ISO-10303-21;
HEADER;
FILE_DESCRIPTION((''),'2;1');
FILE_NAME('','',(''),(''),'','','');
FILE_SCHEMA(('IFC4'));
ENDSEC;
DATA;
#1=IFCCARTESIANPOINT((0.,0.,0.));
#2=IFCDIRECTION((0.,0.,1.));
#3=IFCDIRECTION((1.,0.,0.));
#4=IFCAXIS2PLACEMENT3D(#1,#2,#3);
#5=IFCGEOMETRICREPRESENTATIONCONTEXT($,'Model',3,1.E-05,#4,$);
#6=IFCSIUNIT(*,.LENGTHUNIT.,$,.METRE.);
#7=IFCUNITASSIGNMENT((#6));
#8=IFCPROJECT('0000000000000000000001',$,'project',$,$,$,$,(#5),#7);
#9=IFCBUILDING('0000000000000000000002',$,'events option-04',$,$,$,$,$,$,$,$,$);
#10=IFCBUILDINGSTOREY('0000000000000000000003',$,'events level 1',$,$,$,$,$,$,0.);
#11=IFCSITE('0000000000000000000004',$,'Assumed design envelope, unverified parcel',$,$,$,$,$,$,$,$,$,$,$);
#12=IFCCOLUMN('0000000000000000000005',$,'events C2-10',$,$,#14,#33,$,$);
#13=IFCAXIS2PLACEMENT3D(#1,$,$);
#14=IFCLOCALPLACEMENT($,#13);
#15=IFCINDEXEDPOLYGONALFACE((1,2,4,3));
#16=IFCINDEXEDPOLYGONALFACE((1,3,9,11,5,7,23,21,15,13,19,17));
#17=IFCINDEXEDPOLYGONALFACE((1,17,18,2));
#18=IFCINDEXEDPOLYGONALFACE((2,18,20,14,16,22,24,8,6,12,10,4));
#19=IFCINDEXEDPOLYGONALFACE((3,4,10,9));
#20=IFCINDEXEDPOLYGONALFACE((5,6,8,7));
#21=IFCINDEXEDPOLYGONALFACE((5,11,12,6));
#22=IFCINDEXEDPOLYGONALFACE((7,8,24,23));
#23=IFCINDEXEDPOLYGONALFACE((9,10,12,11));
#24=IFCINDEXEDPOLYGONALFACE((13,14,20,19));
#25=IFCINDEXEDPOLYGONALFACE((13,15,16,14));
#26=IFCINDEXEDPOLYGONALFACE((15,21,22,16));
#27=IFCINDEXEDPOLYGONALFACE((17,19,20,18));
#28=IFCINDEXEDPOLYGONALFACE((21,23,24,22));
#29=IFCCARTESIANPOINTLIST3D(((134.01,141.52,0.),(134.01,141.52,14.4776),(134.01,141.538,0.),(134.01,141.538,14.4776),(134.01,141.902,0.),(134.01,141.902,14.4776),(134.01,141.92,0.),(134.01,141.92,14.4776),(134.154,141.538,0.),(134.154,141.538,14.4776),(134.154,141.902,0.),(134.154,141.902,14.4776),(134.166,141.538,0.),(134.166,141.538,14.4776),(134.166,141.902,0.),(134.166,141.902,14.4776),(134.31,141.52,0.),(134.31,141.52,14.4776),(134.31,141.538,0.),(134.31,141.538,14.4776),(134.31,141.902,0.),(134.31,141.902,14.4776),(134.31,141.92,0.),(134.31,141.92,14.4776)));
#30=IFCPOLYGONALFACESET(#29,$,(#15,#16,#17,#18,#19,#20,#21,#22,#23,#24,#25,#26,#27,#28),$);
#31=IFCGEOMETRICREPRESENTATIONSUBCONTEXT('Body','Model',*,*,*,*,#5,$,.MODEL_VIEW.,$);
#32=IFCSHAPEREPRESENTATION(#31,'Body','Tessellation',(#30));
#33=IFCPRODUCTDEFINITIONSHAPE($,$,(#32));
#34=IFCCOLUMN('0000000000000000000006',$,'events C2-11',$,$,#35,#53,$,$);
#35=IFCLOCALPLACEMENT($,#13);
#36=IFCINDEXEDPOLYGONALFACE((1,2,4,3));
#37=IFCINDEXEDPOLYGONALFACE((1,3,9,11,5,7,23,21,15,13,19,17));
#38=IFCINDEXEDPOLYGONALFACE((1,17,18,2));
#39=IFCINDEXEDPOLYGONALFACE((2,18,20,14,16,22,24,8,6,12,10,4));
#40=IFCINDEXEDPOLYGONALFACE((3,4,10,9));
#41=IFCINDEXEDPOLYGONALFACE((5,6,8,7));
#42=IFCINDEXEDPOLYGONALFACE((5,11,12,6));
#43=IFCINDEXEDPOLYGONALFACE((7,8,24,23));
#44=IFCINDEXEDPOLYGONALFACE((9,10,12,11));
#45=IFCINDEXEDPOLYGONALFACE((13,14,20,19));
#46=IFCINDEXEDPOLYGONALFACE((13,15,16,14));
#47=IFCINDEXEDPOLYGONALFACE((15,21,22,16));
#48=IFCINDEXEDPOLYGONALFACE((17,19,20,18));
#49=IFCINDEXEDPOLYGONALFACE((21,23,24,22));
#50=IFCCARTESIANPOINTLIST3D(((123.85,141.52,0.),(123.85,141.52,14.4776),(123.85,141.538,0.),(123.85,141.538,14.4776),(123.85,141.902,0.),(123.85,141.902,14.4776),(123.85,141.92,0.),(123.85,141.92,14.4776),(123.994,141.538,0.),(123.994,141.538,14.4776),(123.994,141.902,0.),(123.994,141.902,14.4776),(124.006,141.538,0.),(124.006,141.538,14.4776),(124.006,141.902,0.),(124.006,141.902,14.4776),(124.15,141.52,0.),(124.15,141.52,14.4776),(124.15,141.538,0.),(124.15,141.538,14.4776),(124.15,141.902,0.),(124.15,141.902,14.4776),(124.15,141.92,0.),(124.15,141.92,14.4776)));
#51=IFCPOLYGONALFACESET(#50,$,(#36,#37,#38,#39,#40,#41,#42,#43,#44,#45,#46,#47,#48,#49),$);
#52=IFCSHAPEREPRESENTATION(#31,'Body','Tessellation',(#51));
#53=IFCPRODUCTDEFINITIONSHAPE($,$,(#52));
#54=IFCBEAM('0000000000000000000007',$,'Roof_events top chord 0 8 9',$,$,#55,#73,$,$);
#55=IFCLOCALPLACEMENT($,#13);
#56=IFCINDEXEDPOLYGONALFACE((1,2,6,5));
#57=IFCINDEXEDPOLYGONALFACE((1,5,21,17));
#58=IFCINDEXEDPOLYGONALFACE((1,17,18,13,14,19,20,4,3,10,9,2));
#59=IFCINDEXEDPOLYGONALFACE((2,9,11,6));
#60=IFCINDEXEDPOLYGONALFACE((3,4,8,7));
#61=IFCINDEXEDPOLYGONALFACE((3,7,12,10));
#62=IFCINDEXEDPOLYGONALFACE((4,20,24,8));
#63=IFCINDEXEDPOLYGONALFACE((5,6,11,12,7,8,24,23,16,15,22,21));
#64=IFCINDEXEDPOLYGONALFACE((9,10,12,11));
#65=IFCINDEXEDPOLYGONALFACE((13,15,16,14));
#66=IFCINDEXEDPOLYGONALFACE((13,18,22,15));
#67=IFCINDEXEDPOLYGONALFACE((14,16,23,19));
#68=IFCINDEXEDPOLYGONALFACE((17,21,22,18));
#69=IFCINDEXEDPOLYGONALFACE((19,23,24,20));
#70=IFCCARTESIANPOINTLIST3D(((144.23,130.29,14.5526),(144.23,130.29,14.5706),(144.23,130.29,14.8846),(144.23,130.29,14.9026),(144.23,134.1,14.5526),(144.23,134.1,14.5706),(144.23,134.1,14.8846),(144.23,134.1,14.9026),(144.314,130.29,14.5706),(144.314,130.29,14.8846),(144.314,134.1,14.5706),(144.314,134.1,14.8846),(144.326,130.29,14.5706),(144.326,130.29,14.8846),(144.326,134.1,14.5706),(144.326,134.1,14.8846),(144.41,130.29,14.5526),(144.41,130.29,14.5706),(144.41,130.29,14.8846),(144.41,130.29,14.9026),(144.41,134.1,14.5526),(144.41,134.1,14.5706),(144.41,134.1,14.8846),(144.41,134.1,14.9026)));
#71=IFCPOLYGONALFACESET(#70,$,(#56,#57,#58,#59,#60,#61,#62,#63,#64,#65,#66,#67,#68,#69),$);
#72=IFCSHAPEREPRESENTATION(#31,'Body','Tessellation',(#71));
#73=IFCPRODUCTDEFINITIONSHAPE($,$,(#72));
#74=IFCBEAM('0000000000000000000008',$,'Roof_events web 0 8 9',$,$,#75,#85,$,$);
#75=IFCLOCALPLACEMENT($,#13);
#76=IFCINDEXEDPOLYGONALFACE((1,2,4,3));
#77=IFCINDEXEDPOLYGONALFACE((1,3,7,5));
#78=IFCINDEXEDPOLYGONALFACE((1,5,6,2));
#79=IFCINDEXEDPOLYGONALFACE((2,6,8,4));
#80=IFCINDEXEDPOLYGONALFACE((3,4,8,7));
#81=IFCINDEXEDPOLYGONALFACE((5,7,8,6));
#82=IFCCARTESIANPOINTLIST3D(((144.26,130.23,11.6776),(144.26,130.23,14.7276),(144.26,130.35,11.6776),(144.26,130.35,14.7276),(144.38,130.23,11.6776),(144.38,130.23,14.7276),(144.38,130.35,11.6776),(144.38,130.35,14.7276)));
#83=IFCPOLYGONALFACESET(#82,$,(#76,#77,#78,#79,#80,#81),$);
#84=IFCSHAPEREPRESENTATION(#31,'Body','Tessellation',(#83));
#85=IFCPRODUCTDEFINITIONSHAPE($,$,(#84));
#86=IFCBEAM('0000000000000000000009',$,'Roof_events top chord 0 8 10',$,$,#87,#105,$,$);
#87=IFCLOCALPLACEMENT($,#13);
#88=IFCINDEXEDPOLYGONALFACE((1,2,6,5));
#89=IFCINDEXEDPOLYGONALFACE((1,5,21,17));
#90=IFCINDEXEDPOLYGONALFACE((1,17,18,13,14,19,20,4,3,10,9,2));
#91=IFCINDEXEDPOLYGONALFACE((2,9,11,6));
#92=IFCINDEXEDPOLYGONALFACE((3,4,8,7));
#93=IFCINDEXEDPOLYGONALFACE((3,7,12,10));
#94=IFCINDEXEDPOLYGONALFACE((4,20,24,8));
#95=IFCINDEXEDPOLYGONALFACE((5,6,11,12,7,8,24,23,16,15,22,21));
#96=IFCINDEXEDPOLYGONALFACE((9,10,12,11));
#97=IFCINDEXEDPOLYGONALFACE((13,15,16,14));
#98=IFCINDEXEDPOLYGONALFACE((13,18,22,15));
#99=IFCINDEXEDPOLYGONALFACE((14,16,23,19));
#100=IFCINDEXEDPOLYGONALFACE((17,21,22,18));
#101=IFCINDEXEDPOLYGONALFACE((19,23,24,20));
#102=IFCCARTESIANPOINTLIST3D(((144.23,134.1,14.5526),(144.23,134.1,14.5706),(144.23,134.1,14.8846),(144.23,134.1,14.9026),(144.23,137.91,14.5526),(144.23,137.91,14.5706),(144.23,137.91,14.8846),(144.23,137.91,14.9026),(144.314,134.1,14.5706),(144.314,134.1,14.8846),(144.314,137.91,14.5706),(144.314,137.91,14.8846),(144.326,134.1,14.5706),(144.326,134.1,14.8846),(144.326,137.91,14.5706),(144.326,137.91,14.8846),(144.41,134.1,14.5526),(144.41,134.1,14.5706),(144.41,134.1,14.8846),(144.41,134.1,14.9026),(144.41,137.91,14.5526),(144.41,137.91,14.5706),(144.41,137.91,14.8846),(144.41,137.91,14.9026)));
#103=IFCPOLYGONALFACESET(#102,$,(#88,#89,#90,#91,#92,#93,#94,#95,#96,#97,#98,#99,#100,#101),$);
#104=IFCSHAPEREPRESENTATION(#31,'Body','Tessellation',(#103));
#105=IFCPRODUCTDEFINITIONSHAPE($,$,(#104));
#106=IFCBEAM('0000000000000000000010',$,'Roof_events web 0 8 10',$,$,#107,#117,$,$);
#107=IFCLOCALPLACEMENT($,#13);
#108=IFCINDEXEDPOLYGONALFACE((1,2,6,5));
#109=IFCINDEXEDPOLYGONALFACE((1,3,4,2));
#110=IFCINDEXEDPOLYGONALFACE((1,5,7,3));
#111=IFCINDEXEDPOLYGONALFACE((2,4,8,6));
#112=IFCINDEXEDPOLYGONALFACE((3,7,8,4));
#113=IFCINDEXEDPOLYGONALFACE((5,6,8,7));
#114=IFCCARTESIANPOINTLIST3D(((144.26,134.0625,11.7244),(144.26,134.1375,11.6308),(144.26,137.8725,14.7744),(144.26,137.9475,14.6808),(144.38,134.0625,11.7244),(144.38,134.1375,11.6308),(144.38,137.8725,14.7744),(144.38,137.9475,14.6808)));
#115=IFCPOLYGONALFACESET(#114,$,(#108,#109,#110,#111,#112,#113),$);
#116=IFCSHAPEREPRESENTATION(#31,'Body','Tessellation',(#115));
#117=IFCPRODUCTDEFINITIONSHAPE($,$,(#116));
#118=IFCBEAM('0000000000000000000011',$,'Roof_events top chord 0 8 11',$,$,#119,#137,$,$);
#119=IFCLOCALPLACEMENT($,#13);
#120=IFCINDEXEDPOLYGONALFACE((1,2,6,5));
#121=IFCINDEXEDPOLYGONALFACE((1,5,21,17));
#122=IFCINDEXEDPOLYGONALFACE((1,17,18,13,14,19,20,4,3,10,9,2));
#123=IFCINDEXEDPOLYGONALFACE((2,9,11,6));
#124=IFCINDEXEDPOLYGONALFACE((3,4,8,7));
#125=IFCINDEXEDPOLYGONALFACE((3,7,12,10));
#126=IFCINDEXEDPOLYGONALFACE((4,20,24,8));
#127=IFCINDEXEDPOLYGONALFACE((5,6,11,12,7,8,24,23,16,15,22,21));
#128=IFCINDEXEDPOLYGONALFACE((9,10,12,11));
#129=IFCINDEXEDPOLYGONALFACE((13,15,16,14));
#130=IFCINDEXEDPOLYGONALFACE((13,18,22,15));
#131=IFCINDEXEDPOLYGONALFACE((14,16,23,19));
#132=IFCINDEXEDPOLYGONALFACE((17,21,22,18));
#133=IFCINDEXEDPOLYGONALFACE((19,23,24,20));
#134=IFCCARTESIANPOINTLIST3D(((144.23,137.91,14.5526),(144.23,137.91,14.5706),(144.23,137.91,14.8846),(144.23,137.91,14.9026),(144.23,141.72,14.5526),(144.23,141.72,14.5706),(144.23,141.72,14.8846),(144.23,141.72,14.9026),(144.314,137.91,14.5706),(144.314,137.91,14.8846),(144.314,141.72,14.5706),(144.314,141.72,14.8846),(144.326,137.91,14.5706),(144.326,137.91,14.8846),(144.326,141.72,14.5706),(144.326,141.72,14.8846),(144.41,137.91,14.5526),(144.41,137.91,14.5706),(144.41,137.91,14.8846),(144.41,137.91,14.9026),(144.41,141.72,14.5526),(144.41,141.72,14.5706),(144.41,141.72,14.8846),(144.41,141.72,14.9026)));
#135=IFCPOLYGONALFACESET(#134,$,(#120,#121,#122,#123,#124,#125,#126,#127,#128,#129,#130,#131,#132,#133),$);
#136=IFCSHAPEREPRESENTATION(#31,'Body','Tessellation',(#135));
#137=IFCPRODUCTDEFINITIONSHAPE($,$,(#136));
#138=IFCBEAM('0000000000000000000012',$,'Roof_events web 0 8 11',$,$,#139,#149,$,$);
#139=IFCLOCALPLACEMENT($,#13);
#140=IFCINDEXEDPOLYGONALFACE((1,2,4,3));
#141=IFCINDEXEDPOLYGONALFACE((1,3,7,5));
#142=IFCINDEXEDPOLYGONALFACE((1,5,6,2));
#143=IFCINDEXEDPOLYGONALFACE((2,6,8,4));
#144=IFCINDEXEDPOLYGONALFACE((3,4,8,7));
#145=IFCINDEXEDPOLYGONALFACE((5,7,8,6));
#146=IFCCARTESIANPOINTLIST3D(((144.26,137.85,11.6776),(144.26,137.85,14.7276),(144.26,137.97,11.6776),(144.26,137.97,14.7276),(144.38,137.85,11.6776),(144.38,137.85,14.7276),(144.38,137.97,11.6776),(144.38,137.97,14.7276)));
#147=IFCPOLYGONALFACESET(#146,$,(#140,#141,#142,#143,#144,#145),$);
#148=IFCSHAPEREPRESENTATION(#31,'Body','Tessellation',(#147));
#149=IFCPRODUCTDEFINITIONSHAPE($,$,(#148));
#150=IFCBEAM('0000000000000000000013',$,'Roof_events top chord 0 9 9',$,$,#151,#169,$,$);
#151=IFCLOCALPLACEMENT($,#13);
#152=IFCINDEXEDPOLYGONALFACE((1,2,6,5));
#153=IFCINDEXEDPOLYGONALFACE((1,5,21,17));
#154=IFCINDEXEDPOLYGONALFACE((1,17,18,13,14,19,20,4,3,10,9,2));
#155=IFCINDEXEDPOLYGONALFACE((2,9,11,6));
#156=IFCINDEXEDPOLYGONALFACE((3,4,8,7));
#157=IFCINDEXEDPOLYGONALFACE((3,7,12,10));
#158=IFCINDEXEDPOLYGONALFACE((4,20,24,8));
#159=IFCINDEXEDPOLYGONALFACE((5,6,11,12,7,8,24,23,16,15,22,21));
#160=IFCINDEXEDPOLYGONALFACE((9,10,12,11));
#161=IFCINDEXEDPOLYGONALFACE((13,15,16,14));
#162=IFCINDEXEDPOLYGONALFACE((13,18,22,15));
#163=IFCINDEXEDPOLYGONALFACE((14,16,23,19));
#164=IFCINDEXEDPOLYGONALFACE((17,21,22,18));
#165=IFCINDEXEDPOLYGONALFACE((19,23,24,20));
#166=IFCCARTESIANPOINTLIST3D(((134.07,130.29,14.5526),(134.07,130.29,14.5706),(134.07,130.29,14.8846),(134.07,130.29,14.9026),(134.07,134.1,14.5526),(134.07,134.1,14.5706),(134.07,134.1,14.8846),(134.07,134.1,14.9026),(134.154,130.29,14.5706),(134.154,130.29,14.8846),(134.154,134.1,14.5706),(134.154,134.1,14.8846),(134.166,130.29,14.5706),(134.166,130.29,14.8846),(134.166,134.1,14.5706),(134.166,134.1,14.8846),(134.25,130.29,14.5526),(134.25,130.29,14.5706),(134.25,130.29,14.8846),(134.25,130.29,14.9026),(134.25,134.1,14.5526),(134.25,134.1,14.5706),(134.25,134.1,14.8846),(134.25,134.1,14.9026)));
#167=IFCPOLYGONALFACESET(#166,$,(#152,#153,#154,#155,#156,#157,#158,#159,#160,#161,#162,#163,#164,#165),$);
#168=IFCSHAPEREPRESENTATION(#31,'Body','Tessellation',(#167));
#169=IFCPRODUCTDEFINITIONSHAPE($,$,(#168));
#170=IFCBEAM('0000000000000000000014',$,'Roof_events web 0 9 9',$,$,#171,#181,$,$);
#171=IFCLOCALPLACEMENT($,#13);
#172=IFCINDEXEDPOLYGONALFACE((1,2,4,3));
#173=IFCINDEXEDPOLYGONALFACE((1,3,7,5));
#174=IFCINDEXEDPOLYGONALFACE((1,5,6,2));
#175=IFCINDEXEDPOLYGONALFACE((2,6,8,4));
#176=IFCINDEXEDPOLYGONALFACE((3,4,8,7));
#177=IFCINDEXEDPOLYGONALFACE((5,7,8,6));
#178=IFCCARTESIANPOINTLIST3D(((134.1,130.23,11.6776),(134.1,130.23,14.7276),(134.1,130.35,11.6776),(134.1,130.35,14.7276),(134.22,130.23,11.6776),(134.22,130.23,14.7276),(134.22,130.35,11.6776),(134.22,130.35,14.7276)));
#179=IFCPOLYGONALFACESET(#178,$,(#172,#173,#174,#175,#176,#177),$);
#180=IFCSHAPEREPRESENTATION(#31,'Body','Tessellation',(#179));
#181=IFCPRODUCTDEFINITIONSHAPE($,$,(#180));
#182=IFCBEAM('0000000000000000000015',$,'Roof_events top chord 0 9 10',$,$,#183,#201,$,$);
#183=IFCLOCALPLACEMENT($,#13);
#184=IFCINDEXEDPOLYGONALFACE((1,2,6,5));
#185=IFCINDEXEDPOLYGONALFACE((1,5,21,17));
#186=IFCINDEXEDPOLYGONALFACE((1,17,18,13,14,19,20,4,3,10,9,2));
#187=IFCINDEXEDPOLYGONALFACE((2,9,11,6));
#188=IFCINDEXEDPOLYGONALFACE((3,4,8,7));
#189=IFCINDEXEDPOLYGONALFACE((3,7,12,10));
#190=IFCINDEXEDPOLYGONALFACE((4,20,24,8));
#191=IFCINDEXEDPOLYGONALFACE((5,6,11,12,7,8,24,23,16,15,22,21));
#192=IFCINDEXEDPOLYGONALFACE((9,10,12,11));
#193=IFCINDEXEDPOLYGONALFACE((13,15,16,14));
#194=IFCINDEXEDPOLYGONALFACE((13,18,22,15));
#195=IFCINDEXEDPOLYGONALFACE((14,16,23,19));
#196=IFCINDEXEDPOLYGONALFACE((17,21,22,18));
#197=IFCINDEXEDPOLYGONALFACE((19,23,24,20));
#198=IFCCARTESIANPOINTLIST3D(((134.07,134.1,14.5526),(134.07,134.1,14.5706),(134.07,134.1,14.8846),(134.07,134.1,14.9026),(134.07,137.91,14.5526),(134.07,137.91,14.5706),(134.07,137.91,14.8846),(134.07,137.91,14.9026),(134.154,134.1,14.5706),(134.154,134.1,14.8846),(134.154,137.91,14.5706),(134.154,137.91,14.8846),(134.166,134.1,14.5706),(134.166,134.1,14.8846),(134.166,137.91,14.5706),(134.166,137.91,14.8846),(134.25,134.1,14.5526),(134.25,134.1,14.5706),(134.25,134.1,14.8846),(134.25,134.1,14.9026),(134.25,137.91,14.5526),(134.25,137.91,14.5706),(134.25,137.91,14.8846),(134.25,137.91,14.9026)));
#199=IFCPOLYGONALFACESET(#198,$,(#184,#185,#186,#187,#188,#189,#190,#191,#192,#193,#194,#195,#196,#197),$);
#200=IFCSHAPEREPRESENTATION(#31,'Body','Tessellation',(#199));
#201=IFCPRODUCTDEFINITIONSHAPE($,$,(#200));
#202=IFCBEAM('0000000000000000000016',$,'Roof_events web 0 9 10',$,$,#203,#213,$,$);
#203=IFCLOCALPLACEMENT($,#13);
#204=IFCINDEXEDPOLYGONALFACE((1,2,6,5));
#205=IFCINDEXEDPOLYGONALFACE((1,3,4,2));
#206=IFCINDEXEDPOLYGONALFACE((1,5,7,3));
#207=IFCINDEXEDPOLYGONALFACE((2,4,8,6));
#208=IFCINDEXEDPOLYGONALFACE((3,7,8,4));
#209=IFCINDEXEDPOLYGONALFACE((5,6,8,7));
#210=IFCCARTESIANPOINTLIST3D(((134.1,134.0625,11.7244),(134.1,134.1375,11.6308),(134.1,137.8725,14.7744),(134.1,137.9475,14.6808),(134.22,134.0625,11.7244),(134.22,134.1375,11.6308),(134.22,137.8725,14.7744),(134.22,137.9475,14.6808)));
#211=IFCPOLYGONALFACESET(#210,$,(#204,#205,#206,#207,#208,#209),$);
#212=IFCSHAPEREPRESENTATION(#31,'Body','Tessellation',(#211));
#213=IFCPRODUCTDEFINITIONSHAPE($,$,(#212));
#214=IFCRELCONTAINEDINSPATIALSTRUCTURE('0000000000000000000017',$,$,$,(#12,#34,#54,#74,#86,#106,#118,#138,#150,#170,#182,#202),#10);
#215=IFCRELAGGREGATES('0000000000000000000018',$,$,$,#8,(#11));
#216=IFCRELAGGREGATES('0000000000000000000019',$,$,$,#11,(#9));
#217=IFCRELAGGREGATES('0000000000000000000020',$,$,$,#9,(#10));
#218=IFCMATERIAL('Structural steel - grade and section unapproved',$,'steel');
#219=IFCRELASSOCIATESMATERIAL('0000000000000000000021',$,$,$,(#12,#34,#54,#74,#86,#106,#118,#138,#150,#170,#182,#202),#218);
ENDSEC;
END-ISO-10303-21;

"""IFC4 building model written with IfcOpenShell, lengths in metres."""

from ifc_helpers import new_model, si_unit, frame, origin_with_axes, place, context, subcontext, project, spatial, rectangle, i_section, extrude, material, element, save


model = new_model("IFC4")

# Units and contexts
model_context = context("Model", 3, precision=1e-05, world=origin_with_axes())
body_context = subcontext(model_context, "Body", "Model", "MODEL_VIEW")
ifc_project = project(units=[si_unit("LENGTHUNIT", "METRE")], contexts=[model_context])

# Site, building, storey
site = spatial("IfcSite", under=ifc_project, Name="Assumed design envelope, unverified parcel")
building = spatial("IfcBuilding", under=site, Name="events option-04")
storey = spatial("IfcBuildingStorey", under=building, Name="events level 1", Elevation=0.0)

# Columns
ifc_material = material(Name="Structural steel - grade and section unapproved", Category="steel")
for number, where, z_axis, x_axis, name in (
    (1, (134.16, 141.72, 0.0), (0.0, 0.0, 1.0), (-1.0, 0.0, 0.0), "events C2-10"),
    (2, (124.0, 141.72, 0.0), (0.0, 0.0, 1.0), (-1.0, 0.0, 0.0), "events C2-11"),
):
    element("IfcColumn", number, at=place(None, frame(where, z_axis=z_axis, x_axis=x_axis)), inside=storey, material=ifc_material, Name=name, context=body_context, shape_type="SweptSolid", body=[
        extrude(i_section(OverallWidth=0.3, OverallDepth=0.4, WebThickness=0.012, FlangeThickness=0.018, FilletRadius=0.0), origin_with_axes(), (0.0, 0.0, 1.0), 14.4776),
    ])

# Beams
beam_1_placement = place(None, frame((144.32, 130.29, 14.7276), z_axis=(0.0, 1.0, 0.0), x_axis=(-1.0, 0.0, 0.0)))
element("IfcBeam", 3, at=beam_1_placement, inside=storey, material=ifc_material, Name="Roof_events top chord 0 8 9", context=body_context, shape_type="SweptSolid", body=[
    extrude(i_section(OverallWidth=0.18, OverallDepth=0.35, WebThickness=0.012, FlangeThickness=0.018, FilletRadius=0.0), origin_with_axes(), (0.0, 0.0, 1.0), 3.81),
])
beam_2_placement = place(None, frame((144.32, 130.29, 11.6776), z_axis=(0.0, 0.0, 1.0), x_axis=(-1.0, 0.0, 0.0)))
element("IfcBeam", 4, at=beam_2_placement, inside=storey, material=ifc_material, Name="Roof_events web 0 8 9", context=body_context, shape_type="SweptSolid", body=[
    extrude(rectangle(XDim=0.12, YDim=0.12), origin_with_axes(), (0.0, 0.0, 1.0), 3.05),
])
beam_3_placement = place(None, frame((144.32, 134.1, 14.7276), z_axis=(0.0, 1.0, 0.0), x_axis=(-1.0, 0.0, 0.0)))
element("IfcBeam", 5, at=beam_3_placement, inside=storey, material=ifc_material, Name="Roof_events top chord 0 8 10", context=body_context, shape_type="SweptSolid", body=[
    extrude(i_section(OverallWidth=0.18, OverallDepth=0.35, WebThickness=0.012, FlangeThickness=0.018, FilletRadius=0.0), origin_with_axes(), (0.0, 0.0, 1.0), 3.81),
])
beam_4_placement = place(None, frame((144.32, 134.1, 11.6776), z_axis=(0.0, 0.780669, 0.624945), x_axis=(-1.0, 0.0, 0.0)))
element("IfcBeam", 6, at=beam_4_placement, inside=storey, material=ifc_material, Name="Roof_events web 0 8 10", context=body_context, shape_type="SweptSolid", body=[
    extrude(rectangle(XDim=0.12, YDim=0.12), origin_with_axes(), (0.0, 0.0, 1.0), 4.8804),
])
beam_5_placement = place(None, frame((144.32, 137.91, 14.7276), z_axis=(0.0, 1.0, 0.0), x_axis=(-1.0, 0.0, 0.0)))
element("IfcBeam", 7, at=beam_5_placement, inside=storey, material=ifc_material, Name="Roof_events top chord 0 8 11", context=body_context, shape_type="SweptSolid", body=[
    extrude(i_section(OverallWidth=0.18, OverallDepth=0.35, WebThickness=0.012, FlangeThickness=0.018, FilletRadius=0.0), origin_with_axes(), (0.0, 0.0, 1.0), 3.81),
])
beam_6_placement = place(None, frame((144.32, 137.91, 11.6776), z_axis=(0.0, 0.0, 1.0), x_axis=(-1.0, 0.0, 0.0)))
element("IfcBeam", 8, at=beam_6_placement, inside=storey, material=ifc_material, Name="Roof_events web 0 8 11", context=body_context, shape_type="SweptSolid", body=[
    extrude(rectangle(XDim=0.12, YDim=0.12), origin_with_axes(), (0.0, 0.0, 1.0), 3.05),
])
beam_7_placement = place(None, frame((134.16, 130.29, 14.7276), z_axis=(0.0, 1.0, 0.0), x_axis=(-1.0, 0.0, 0.0)))
element("IfcBeam", 9, at=beam_7_placement, inside=storey, material=ifc_material, Name="Roof_events top chord 0 9 9", context=body_context, shape_type="SweptSolid", body=[
    extrude(i_section(OverallWidth=0.18, OverallDepth=0.35, WebThickness=0.012, FlangeThickness=0.018, FilletRadius=0.0), origin_with_axes(), (0.0, 0.0, 1.0), 3.81),
])
beam_8_placement = place(None, frame((134.16, 130.29, 11.6776), z_axis=(0.0, 0.0, 1.0), x_axis=(-1.0, 0.0, 0.0)))
element("IfcBeam", 10, at=beam_8_placement, inside=storey, material=ifc_material, Name="Roof_events web 0 9 9", context=body_context, shape_type="SweptSolid", body=[
    extrude(rectangle(XDim=0.12, YDim=0.12), origin_with_axes(), (0.0, 0.0, 1.0), 3.05),
])
beam_9_placement = place(None, frame((134.16, 134.1, 14.7276), z_axis=(0.0, 1.0, 0.0), x_axis=(-1.0, 0.0, 0.0)))
element("IfcBeam", 11, at=beam_9_placement, inside=storey, material=ifc_material, Name="Roof_events top chord 0 9 10", context=body_context, shape_type="SweptSolid", body=[
    extrude(i_section(OverallWidth=0.18, OverallDepth=0.35, WebThickness=0.012, FlangeThickness=0.018, FilletRadius=0.0), origin_with_axes(), (0.0, 0.0, 1.0), 3.81),
])
beam_10_placement = place(None, frame((134.16, 134.1, 11.6776), z_axis=(0.0, 0.780669, 0.624945), x_axis=(-1.0, 0.0, 0.0)))
element("IfcBeam", 12, at=beam_10_placement, inside=storey, material=ifc_material, Name="Roof_events web 0 9 10", context=body_context, shape_type="SweptSolid", body=[
    extrude(rectangle(XDim=0.12, YDim=0.12), origin_with_axes(), (0.0, 0.0, 1.0), 4.8804),
])

save(model, "model.ifc")
